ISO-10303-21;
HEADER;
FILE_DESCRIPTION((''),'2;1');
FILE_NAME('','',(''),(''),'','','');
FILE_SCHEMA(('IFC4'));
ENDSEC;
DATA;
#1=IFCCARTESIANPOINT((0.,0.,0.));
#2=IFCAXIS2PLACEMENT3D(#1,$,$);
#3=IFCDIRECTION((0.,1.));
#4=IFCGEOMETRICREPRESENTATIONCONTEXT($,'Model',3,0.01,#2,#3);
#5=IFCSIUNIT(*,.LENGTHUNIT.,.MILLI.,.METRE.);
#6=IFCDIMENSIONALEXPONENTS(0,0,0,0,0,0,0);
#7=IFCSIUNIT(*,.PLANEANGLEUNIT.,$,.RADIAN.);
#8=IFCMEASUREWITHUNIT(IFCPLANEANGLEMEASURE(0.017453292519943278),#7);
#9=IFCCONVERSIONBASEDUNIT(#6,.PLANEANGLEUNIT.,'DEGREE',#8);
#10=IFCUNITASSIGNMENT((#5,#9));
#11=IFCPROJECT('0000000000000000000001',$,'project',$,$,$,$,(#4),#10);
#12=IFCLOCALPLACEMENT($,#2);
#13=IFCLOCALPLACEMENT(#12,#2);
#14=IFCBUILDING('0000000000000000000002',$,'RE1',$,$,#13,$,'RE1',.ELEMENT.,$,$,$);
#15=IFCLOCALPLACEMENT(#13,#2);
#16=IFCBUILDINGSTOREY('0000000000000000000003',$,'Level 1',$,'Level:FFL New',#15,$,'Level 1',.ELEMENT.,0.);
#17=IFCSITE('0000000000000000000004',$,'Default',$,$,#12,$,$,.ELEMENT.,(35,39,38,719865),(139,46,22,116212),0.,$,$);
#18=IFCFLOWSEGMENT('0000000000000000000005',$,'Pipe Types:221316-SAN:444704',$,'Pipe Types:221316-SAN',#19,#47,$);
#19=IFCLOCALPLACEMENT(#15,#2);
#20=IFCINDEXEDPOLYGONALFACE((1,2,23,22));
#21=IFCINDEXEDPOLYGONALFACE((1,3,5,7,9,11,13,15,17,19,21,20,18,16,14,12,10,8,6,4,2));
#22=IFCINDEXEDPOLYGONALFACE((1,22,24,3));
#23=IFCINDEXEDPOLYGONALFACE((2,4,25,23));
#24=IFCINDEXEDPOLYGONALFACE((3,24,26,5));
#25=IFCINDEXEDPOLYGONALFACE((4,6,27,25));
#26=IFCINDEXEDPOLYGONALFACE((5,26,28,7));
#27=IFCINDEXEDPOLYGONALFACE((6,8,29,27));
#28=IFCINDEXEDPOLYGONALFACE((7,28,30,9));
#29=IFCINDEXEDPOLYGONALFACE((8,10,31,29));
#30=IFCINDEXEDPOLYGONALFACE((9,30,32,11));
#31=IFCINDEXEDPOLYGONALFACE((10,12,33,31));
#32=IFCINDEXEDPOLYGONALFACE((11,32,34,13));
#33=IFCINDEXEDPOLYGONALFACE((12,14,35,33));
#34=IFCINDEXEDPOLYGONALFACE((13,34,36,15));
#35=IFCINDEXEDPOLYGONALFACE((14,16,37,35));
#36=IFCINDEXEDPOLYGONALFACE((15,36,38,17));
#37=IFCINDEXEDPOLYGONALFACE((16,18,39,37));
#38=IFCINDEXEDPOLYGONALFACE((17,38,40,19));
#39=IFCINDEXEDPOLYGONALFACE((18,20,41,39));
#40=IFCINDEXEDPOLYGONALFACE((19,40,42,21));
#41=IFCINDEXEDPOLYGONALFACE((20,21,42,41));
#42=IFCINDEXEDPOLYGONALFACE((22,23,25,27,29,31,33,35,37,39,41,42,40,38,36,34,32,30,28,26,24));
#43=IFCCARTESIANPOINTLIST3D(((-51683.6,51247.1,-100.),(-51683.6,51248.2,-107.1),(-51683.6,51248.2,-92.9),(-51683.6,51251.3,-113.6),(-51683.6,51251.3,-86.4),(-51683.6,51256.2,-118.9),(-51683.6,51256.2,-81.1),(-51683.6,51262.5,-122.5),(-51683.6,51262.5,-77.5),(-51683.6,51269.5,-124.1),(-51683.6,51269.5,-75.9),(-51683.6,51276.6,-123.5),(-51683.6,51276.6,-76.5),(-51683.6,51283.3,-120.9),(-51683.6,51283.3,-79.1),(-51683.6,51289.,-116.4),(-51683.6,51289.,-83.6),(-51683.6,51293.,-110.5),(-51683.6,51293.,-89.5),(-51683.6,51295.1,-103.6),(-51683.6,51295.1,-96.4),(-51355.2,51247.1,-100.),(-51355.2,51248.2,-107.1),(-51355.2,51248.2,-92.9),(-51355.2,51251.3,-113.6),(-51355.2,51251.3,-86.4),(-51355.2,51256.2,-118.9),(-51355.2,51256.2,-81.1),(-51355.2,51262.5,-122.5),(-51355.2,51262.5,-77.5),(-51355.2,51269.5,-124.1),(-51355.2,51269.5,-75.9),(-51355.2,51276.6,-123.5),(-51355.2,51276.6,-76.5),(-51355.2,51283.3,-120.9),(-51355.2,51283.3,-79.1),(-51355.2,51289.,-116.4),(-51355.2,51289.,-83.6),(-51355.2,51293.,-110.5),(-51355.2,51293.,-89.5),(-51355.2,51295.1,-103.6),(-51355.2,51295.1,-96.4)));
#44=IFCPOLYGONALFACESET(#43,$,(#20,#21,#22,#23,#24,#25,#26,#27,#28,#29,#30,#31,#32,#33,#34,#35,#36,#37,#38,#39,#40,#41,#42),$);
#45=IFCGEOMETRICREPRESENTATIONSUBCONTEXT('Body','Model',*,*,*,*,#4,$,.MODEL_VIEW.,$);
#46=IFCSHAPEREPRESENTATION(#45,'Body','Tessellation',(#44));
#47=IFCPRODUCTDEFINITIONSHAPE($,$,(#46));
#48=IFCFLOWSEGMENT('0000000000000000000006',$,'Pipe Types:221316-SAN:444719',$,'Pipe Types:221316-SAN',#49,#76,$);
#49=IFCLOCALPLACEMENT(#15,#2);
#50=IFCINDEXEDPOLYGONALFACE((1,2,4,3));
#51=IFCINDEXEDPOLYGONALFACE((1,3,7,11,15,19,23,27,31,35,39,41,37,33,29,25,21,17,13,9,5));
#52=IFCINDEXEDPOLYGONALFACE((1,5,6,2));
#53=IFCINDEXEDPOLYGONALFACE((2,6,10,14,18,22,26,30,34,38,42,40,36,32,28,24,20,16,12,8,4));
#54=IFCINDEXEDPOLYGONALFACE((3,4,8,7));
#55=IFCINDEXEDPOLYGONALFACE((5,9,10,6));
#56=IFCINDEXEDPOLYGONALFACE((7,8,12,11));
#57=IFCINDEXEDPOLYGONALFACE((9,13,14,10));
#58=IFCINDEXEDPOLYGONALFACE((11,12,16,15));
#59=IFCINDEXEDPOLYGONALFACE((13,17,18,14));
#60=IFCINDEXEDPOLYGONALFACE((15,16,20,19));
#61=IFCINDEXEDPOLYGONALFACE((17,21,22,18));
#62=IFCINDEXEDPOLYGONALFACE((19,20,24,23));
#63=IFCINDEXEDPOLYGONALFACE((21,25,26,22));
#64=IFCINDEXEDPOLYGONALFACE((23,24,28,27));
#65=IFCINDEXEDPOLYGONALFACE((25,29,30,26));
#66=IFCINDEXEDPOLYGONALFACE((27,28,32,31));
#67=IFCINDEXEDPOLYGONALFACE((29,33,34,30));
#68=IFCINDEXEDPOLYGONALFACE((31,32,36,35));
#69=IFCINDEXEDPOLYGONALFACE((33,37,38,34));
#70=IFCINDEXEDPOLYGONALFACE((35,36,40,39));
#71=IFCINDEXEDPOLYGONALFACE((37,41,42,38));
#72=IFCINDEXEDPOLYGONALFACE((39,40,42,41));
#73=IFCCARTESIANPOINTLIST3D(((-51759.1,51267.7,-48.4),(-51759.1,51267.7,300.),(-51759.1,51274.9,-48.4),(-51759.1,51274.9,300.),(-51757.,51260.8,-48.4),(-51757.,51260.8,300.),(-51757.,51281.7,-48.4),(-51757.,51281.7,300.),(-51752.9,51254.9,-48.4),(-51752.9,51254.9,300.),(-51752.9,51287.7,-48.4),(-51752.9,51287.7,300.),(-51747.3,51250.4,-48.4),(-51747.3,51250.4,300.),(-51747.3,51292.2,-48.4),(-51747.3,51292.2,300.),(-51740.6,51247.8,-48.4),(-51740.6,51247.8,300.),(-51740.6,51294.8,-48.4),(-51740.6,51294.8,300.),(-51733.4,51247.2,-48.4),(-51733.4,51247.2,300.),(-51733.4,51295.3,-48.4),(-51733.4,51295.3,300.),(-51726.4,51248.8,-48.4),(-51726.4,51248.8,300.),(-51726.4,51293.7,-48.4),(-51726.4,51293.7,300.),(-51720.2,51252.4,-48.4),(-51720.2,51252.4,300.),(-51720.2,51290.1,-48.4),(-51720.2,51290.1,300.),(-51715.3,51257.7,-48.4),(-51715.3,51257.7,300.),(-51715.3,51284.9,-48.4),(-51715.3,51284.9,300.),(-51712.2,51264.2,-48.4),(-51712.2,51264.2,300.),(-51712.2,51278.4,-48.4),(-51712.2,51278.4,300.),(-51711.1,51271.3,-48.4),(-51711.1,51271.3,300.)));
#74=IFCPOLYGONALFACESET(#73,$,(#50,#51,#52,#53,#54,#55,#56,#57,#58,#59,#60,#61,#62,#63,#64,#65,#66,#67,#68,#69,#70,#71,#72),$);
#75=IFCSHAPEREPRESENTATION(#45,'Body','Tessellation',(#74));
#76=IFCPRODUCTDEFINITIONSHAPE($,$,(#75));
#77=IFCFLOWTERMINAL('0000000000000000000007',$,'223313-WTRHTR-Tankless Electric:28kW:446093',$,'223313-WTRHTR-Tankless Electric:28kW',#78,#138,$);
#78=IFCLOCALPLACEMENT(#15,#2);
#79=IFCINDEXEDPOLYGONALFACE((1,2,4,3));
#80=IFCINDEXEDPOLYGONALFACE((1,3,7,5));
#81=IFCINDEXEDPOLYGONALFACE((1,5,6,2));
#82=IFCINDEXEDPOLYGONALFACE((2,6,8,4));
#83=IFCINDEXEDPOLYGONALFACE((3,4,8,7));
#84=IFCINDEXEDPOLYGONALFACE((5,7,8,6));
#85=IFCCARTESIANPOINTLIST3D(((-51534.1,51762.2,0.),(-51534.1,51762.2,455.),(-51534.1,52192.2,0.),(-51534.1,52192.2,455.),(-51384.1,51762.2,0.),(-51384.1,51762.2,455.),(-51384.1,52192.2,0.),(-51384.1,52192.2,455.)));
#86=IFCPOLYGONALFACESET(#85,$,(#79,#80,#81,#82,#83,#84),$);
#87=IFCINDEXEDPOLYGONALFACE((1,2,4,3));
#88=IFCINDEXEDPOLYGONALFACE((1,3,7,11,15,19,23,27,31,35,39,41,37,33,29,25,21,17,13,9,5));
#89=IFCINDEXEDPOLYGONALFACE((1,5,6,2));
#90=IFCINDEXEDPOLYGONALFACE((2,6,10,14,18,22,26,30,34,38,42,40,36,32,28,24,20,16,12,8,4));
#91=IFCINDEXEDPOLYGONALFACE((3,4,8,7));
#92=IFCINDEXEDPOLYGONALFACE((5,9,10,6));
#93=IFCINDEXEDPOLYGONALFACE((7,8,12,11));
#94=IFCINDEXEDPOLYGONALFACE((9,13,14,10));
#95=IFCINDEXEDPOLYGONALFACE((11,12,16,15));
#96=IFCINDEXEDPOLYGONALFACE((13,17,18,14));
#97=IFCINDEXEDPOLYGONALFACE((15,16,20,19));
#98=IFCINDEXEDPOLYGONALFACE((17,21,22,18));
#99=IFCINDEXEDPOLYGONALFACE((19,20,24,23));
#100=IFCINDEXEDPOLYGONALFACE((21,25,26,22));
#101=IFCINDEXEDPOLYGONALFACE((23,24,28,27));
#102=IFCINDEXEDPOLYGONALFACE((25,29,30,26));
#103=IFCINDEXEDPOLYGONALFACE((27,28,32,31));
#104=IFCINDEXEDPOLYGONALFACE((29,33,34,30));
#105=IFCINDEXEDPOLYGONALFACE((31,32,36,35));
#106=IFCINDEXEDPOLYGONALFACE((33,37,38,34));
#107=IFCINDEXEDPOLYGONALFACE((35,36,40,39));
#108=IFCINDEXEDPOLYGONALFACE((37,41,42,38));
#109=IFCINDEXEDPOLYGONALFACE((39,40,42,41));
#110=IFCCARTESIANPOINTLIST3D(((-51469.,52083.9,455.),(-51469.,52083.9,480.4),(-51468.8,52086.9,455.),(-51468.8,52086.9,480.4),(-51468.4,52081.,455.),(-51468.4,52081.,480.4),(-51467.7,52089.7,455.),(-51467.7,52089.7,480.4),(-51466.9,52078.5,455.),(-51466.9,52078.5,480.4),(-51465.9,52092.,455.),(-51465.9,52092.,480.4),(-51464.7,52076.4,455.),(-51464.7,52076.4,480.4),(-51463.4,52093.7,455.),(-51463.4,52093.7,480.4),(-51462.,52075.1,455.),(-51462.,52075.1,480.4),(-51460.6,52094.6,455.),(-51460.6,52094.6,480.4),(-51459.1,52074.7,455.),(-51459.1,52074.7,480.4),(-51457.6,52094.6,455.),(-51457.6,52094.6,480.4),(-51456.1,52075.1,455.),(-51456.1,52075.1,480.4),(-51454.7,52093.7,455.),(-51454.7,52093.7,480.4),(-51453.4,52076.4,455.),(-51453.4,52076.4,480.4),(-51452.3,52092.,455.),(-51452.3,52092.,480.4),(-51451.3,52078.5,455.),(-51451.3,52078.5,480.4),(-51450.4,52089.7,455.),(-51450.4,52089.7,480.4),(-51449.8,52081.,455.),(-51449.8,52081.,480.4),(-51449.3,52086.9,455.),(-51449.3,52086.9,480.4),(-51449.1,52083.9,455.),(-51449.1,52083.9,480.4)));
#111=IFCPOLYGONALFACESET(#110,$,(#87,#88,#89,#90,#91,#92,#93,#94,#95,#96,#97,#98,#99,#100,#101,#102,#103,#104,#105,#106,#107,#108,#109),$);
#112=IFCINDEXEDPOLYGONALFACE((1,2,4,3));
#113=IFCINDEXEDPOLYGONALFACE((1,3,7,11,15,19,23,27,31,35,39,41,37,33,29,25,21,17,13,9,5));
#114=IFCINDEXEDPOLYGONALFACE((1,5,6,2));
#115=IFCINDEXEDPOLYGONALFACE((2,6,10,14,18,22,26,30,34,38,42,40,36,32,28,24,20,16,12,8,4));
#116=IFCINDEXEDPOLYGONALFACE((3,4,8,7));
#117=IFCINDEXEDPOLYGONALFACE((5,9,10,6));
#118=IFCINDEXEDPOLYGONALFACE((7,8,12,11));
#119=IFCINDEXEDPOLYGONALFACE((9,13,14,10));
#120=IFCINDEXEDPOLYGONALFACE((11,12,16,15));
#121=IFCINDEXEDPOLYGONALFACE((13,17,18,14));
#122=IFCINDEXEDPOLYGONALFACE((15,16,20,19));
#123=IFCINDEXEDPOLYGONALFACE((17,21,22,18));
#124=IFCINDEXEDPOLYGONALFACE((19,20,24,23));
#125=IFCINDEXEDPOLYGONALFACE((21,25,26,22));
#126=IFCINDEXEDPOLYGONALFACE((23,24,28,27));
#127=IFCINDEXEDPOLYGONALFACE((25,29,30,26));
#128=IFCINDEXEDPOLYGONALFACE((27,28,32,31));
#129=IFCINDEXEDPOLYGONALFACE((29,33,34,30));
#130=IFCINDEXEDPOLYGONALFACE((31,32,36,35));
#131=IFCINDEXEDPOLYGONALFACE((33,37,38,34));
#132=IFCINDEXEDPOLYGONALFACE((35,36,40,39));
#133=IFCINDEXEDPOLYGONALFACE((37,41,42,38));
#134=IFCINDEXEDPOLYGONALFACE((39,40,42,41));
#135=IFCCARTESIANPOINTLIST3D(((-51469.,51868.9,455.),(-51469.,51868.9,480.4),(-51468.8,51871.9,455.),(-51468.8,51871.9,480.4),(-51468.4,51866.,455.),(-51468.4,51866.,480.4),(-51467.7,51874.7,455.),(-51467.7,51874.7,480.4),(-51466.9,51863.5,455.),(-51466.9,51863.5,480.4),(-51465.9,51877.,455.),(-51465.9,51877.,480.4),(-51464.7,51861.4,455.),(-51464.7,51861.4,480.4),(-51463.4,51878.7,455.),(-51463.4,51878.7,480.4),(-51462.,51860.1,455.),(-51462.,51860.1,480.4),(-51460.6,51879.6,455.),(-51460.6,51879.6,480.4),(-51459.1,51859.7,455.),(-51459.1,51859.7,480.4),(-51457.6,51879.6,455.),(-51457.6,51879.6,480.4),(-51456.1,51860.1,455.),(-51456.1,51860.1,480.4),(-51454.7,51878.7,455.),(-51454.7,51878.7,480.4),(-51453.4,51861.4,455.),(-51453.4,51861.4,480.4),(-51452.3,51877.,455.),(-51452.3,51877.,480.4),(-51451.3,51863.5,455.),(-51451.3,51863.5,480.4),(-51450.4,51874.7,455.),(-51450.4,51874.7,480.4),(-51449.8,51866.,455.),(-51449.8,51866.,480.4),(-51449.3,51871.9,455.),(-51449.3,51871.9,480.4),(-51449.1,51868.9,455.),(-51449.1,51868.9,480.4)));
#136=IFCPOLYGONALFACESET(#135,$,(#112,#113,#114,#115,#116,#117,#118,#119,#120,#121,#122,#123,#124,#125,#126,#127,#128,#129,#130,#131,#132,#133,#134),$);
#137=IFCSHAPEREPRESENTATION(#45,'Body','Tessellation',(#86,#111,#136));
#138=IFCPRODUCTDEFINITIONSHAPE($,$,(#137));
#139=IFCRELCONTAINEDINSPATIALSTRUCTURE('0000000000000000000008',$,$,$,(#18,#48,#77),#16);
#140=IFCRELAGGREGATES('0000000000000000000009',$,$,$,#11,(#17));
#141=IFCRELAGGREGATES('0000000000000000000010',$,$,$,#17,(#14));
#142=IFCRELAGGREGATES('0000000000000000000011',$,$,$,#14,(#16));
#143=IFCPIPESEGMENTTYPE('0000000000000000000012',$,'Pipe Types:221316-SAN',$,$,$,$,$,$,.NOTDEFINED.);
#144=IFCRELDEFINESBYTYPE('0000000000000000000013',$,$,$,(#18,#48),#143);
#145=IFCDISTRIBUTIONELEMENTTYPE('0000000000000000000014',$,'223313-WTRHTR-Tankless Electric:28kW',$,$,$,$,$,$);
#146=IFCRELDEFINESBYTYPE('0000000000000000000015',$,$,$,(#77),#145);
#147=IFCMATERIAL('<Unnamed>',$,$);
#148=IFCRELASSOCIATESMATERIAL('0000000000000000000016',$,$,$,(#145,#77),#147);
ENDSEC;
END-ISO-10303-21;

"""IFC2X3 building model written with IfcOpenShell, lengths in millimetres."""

from ifc_helpers import new_model, entity, si_unit, converted_unit, direction, frame, frame_2d, origin, origin_2d_with_axis, place, context, subcontext, project, spatial, rectangle, circle, extrude, source, transform, mapped, material, type_object, type_shapes, element, save


model = new_model("IFC2X3")

# Units and contexts
model_context = context("Model", 3, precision=0.01, world=origin(), true_north=direction((0.0, 1.0)))
body_context = subcontext(model_context, "Body", "Model", "MODEL_VIEW")
ifc_project = project(units=[si_unit("LENGTHUNIT", "METRE", prefix="MILLI"), converted_unit("PLANEANGLEUNIT", "DEGREE", entity("IfcPlaneAngleMeasure", 0.017453292519943278), si_unit("PLANEANGLEUNIT", "RADIAN"), dimensions=[0, 0, 0, 0, 0, 0, 0])], contexts=[model_context])

# Site, building, storey
site_placement = place(None, origin())
site = spatial("IfcSite", under=ifc_project, at=site_placement, Name="Default", CompositionType="ELEMENT", RefLatitude=(35, 39, 38, 719865), RefLongitude=(139, 46, 22, 116212), RefElevation=0.0)
building_placement = place(site_placement, origin())
building = spatial("IfcBuilding", under=site, at=building_placement, Name="RE1", LongName="RE1", CompositionType="ELEMENT")
storey_placement = place(building_placement, origin())
storey = spatial("IfcBuildingStorey", under=building, at=storey_placement, Name="Level 1", ObjectType="Level:FFL New", LongName="Level 1", CompositionType="ELEMENT", Elevation=0.0)

# Shared definitions
ifc_material = material(Name="<Unnamed>")

# Flow segments
pipe_segment_type_1 = type_object("IfcPipeSegmentType", Name="Pipe Types:221316-SAN", PredefinedType="NOTDEFINED")
flow_segment_1_placement = place(storey_placement, origin())
element("IfcFlowSegment", 1, at=flow_segment_1_placement, inside=storey, type_object=pipe_segment_type_1, Name="Pipe Types:221316-SAN:444704", ObjectType="Pipe Types:221316-SAN", context=body_context, shape_type="SweptSolid", body=[
    extrude(circle(Radius=24.1, at=frame_2d((0.0, 0.0), x_axis=(1.0, 0.0))), frame((-51683.6, 51271.3, -100.0), z_axis=(1.0, 0.0, 0.0), x_axis=(0.0, -1.0, 0.0)), (0.0, 0.0, 1.0), 328.4),
])
flow_segment_2_placement = place(storey_placement, origin())
element("IfcFlowSegment", 2, at=flow_segment_2_placement, inside=storey, type_object=pipe_segment_type_1, Name="Pipe Types:221316-SAN:444719", ObjectType="Pipe Types:221316-SAN", context=body_context, shape_type="SweptSolid", body=[
    extrude(circle(Radius=24.1, at=frame_2d((0.0, 0.0), x_axis=(1.0, 0.0))), frame((-51735.2, 51271.3, -48.4)), (0.0, 0.0, 1.0), 348.4),
])

# Flow terminal
distribution_element_type_1 = type_object("IfcDistributionElementType", Name="223313-WTRHTR-Tankless Electric:28kW", material=ifc_material)
shared_shape_1 = source(origin(), body_context, "Body", "SweptSolid", [
    extrude(rectangle(XDim=430.0, YDim=150.0, at=origin_2d_with_axis()), frame((0.0, 0.0, 0.0), z_axis=(0.0, 0.0, 1.0), x_axis=(-1.0, 0.0, 0.0)), (0.0, 0.0, 1.0), 455.0),
    extrude(circle(Radius=10.0, at=frame_2d((0.0, 0.0), x_axis=(1.0, 0.0))), frame((-107.5, 0.0, 455.0)), (0.0, 0.0, 1.0), 25.4),
    extrude(circle(Radius=10.0, at=frame_2d((0.0, 0.0), x_axis=(1.0, 0.0))), frame((107.5, 0.0, 455.0)), (0.0, 0.0, 1.0), 25.4),
])
type_shapes(distribution_element_type_1, [shared_shape_1])
flow_terminal_1_placement = place(storey_placement, frame((-51459.1, 51977.2, 0.0), z_axis=(0.0, 0.0, 1.0), x_axis=(0.000011, -1.0, 0.0)))
element("IfcFlowTerminal", 3, at=flow_terminal_1_placement, inside=storey, type_object=distribution_element_type_1, material=ifc_material, Name="223313-WTRHTR-Tankless Electric:28kW:446093", ObjectType="223313-WTRHTR-Tankless Electric:28kW", context=body_context, shape_type="MappedRepresentation", body=[
    mapped(shared_shape_1, transform((0.0, 0.0, 0.0), scale=1.0)),
])

save(model, "model.ifc")
